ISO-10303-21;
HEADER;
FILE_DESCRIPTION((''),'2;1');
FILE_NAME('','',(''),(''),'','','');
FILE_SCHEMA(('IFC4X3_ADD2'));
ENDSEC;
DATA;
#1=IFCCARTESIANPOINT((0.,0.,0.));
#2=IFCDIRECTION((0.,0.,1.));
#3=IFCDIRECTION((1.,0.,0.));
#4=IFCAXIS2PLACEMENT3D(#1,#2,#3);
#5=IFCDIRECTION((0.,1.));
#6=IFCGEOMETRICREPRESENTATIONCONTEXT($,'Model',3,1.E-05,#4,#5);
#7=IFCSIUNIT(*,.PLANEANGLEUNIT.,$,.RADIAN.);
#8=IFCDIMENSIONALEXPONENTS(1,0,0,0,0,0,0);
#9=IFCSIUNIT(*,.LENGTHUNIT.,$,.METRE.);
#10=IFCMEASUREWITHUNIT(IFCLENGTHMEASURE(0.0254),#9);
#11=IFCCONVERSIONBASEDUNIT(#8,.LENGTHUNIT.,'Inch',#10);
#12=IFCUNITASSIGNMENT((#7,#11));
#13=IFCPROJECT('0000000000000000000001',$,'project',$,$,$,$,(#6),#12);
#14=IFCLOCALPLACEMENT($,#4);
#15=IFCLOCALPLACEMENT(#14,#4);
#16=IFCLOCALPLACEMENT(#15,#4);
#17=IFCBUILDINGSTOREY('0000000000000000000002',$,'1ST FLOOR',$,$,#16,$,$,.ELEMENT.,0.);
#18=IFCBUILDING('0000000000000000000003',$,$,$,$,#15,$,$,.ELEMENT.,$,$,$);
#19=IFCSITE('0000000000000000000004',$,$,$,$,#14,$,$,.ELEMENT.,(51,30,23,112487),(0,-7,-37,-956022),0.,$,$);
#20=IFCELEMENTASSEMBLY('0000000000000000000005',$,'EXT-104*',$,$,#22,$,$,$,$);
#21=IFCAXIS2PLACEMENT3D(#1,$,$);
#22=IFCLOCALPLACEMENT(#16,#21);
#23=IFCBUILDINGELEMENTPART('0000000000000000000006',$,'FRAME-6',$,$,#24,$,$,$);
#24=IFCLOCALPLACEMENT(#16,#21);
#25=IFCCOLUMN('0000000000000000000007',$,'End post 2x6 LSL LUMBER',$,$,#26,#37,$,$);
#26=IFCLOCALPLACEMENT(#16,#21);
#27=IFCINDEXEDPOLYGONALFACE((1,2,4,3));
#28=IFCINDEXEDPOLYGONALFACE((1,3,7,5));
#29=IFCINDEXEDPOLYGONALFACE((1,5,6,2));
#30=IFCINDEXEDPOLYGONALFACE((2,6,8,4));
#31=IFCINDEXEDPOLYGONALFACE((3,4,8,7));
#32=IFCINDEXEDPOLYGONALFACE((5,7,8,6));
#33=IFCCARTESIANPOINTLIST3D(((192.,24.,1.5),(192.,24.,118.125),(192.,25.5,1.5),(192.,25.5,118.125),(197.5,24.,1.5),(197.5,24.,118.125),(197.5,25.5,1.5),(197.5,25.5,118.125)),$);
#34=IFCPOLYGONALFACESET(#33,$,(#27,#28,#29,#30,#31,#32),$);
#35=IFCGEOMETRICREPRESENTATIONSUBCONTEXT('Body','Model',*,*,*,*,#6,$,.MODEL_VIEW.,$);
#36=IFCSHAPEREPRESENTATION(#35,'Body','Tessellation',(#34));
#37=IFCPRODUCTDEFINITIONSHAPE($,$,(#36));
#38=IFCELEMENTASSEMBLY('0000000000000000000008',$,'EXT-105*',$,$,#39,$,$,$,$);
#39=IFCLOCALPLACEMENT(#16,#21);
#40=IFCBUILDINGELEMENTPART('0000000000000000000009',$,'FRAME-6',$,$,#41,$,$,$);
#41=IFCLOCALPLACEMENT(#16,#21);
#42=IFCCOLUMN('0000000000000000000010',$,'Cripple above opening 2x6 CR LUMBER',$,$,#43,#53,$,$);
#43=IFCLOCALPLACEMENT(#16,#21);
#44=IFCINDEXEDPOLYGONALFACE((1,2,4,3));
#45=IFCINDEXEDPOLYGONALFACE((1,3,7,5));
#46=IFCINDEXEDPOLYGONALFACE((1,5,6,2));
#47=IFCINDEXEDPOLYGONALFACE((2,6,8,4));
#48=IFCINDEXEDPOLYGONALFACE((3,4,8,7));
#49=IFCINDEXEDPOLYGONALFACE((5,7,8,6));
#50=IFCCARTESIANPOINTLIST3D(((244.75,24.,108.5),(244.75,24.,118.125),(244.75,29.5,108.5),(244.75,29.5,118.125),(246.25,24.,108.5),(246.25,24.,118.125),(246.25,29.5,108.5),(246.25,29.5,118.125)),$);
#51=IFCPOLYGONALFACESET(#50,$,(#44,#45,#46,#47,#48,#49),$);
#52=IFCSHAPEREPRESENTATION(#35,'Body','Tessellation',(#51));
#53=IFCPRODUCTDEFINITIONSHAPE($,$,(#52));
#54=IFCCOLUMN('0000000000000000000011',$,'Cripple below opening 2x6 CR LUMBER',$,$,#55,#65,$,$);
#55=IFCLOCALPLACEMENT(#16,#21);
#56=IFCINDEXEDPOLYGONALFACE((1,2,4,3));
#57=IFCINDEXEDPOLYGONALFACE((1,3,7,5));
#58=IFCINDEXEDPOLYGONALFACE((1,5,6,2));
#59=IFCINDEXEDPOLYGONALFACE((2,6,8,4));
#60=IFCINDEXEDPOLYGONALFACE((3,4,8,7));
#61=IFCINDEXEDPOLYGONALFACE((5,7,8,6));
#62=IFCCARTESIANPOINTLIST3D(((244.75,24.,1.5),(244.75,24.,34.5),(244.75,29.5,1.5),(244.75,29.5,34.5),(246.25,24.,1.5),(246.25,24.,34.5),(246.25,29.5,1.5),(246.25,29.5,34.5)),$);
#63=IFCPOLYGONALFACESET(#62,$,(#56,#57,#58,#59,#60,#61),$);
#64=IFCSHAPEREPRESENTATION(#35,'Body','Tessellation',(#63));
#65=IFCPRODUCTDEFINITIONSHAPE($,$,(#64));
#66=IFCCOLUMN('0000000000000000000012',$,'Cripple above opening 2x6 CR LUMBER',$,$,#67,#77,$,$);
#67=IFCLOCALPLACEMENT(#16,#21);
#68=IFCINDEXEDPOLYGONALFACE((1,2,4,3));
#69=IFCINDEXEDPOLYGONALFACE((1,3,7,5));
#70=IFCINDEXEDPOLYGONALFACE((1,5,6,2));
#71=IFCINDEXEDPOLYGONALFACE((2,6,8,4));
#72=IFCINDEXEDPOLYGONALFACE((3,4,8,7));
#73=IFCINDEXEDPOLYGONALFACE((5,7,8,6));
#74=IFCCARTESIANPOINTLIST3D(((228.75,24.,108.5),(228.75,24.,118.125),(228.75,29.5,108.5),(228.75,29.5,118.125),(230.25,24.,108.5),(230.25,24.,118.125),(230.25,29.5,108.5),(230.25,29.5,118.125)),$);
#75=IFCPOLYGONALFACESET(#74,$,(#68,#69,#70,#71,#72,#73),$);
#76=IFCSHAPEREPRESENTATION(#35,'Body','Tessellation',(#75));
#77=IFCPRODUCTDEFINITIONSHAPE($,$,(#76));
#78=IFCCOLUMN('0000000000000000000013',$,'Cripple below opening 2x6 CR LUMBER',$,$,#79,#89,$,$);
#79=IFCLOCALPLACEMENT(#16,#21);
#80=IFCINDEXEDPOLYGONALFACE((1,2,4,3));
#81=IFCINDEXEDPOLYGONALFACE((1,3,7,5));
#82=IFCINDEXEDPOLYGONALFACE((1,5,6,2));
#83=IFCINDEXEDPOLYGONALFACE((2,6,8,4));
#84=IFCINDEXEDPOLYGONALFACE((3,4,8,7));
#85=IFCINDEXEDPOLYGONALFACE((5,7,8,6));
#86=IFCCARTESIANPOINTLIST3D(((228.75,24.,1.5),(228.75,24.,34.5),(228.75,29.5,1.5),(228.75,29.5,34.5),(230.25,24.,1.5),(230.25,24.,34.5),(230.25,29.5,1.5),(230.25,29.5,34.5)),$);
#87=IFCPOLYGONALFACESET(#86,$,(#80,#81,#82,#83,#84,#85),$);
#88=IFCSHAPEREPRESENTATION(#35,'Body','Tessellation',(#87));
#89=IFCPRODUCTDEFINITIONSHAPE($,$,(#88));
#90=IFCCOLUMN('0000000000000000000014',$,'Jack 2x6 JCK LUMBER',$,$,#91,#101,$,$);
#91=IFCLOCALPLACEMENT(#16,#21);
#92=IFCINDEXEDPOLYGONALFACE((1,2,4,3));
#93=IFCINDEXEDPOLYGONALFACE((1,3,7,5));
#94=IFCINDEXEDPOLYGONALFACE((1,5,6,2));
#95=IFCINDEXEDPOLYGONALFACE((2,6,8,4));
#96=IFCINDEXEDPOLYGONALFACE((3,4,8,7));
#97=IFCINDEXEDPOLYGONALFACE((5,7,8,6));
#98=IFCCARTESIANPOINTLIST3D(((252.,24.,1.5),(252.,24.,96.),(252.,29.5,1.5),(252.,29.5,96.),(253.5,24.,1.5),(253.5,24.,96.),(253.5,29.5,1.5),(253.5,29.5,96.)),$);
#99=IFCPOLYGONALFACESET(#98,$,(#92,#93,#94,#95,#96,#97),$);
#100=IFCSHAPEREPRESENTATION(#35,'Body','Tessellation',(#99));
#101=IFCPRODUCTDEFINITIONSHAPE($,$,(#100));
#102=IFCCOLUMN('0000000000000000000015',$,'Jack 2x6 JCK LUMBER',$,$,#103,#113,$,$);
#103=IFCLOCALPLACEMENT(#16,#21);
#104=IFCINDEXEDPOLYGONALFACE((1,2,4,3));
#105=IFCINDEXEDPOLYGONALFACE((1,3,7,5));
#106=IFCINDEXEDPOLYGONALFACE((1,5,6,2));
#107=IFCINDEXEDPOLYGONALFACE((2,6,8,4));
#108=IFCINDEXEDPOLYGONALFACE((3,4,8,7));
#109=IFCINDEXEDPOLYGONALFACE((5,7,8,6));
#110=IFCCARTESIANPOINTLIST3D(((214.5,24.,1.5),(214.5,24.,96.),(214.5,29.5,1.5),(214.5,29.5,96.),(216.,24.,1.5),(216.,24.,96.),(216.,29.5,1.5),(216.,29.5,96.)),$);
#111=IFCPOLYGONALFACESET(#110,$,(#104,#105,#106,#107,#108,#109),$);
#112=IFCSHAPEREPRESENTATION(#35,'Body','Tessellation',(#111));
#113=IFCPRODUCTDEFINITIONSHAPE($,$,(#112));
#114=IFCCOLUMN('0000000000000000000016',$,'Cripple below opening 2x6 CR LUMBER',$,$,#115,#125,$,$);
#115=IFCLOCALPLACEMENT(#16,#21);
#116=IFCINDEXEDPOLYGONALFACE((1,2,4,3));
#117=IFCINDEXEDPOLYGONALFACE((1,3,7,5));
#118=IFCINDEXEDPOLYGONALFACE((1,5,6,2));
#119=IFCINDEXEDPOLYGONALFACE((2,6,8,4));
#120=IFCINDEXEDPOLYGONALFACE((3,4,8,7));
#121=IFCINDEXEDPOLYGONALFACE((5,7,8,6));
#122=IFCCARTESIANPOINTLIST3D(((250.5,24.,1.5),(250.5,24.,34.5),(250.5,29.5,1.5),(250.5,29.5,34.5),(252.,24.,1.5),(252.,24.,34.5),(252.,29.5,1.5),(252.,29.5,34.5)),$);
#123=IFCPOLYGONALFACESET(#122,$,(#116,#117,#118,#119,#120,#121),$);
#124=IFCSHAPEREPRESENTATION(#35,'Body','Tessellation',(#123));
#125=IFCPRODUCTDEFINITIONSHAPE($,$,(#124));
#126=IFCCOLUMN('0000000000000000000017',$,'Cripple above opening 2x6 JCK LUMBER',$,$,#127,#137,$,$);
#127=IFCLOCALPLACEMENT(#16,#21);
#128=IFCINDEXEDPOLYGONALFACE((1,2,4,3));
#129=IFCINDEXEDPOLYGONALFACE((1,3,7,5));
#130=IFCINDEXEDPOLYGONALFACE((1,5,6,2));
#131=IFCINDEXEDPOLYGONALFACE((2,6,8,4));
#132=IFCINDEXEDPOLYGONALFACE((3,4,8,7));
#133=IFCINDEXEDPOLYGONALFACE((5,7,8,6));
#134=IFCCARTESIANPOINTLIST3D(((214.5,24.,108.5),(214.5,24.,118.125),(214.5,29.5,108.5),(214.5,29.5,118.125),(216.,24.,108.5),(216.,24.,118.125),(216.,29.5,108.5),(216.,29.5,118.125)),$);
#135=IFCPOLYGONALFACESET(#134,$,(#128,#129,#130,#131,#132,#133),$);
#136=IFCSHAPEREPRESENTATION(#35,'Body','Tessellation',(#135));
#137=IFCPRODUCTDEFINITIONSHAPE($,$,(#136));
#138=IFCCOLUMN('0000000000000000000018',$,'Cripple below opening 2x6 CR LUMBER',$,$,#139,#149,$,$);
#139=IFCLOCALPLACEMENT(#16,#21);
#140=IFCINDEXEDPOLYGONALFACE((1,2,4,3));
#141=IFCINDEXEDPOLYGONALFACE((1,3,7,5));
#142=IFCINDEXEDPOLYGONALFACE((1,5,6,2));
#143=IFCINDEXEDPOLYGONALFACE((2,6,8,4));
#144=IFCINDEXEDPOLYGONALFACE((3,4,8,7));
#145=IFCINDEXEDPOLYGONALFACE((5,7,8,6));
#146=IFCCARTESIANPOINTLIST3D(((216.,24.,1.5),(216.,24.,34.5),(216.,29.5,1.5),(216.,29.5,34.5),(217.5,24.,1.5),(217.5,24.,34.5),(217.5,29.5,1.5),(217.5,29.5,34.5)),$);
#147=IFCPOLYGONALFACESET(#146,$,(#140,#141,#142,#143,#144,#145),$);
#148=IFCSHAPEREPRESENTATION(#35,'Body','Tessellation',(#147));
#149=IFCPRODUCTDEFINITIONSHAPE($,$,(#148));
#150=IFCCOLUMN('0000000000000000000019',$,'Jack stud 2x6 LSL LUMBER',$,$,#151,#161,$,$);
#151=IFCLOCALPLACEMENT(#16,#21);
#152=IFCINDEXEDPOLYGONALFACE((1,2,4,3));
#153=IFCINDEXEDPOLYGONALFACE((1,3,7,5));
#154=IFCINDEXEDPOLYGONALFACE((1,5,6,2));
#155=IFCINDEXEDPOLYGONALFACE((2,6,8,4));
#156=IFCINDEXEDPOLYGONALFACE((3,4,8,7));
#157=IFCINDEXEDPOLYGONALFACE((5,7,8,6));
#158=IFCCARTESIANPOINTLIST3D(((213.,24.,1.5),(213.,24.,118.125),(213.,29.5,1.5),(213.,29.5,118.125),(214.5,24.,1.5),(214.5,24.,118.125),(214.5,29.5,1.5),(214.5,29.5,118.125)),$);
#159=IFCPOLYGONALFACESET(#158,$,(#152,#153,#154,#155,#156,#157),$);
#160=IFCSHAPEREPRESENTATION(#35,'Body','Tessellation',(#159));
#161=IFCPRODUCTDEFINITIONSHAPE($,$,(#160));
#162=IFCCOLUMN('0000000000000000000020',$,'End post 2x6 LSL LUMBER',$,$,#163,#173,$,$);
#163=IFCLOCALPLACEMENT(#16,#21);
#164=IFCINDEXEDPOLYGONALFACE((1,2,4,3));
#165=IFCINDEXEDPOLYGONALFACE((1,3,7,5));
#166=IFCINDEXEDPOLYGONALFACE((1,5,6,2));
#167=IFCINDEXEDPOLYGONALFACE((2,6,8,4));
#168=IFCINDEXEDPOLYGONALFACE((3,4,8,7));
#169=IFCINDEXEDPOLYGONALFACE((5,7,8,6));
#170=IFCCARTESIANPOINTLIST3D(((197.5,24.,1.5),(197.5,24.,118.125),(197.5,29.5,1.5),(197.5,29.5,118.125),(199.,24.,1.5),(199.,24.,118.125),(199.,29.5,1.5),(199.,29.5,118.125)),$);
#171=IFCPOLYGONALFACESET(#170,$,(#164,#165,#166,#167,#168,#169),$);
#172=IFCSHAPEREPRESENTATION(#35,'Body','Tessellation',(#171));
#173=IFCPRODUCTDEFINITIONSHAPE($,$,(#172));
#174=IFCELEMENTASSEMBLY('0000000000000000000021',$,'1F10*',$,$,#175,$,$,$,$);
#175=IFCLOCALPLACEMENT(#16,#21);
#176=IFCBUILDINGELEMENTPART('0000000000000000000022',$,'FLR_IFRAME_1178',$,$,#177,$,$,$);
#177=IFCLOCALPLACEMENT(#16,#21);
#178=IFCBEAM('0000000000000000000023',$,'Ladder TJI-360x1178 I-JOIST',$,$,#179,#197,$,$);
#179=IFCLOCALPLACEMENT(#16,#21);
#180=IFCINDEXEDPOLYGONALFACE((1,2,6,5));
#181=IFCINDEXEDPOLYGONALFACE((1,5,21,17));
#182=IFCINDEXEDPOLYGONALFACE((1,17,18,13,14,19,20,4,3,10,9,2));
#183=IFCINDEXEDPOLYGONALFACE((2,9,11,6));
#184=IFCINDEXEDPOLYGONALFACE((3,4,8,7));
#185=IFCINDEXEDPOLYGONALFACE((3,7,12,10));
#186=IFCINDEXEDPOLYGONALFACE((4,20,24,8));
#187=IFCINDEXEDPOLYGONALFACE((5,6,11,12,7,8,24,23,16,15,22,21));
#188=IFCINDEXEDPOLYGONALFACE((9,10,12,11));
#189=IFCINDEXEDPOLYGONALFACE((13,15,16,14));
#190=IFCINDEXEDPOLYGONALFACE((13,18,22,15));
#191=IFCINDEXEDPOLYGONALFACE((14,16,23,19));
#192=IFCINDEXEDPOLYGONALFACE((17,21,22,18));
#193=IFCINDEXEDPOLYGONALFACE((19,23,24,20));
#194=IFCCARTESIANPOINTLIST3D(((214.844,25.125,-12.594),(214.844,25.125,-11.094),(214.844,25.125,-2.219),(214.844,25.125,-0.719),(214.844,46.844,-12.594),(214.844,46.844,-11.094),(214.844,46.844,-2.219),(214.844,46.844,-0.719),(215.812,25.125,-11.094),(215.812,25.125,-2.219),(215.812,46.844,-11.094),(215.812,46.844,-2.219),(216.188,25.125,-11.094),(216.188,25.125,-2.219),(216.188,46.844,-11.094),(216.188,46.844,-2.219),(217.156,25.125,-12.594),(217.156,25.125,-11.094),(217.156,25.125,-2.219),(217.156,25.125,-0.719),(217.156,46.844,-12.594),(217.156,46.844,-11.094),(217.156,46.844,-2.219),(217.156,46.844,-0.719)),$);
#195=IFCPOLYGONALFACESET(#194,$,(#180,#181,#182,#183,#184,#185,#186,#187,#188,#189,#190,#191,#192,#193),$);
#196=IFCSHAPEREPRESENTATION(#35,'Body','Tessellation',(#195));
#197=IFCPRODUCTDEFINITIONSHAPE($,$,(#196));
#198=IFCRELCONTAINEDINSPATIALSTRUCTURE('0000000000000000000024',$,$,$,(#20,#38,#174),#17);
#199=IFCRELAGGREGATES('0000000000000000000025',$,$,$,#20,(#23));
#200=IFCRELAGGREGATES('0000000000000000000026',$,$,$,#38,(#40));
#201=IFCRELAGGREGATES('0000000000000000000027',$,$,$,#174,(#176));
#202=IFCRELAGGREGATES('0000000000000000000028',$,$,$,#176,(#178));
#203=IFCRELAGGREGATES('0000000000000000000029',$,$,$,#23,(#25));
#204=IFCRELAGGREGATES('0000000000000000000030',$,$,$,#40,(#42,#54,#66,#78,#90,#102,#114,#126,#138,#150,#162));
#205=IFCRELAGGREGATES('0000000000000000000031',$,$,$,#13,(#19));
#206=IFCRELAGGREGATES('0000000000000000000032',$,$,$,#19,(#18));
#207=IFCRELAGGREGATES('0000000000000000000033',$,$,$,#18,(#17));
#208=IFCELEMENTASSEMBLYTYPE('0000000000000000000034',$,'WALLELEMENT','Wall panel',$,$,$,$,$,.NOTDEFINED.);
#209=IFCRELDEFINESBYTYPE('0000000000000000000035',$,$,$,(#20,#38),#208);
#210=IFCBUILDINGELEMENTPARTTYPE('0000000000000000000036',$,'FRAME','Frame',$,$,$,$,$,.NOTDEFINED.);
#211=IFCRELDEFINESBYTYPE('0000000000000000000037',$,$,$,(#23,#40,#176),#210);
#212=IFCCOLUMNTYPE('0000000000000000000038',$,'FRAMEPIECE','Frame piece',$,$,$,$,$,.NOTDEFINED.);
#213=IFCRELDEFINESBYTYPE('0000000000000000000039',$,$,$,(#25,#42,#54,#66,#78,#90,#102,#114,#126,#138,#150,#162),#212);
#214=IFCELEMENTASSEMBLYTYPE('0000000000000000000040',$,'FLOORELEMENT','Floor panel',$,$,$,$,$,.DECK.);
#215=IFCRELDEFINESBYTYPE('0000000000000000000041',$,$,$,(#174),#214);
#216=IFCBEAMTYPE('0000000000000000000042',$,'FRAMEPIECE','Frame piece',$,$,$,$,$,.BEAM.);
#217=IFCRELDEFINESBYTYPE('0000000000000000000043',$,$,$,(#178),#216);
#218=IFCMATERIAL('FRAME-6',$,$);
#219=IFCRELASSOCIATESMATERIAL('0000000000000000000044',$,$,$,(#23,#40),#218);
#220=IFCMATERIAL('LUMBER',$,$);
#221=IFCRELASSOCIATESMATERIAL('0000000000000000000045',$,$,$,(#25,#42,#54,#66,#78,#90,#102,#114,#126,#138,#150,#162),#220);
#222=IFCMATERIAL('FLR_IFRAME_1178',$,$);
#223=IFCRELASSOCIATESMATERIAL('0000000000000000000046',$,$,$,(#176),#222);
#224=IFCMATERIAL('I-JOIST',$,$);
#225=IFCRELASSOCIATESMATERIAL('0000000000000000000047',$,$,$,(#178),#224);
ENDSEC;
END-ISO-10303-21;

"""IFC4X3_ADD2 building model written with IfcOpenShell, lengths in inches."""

from ifc_helpers import new_model, entity, si_unit, converted_unit, direction, frame, origin_with_axes, origin_2d_with_axis, place, context, subcontext, project, spatial, rectangle, i_section, extrude, material, type_object, element, aggregate, save


model = new_model("IFC4X3_ADD2")

# Units and contexts
model_context = context("Model", 3, precision=1e-05, world=origin_with_axes(), true_north=direction((0.0, 1.0)))
body_context = subcontext(model_context, "Body", "Model", "MODEL_VIEW")
ifc_project = project(units=[si_unit("PLANEANGLEUNIT", "RADIAN"), converted_unit("LENGTHUNIT", "Inch", entity("IfcLengthMeasure", 0.0254), si_unit("LENGTHUNIT", "METRE"), dimensions=[1, 0, 0, 0, 0, 0, 0])], contexts=[model_context])

# Site, building, storey
site_placement = place(None, origin_with_axes())
site = spatial("IfcSite", under=ifc_project, at=site_placement, CompositionType="ELEMENT", RefLatitude=(51, 30, 23, 112487), RefLongitude=(0, -7, -37, -956022), RefElevation=0.0)
building_placement = place(site_placement, origin_with_axes())
building = spatial("IfcBuilding", under=site, at=building_placement, CompositionType="ELEMENT")
storey_placement = place(building_placement, origin_with_axes())
storey = spatial("IfcBuildingStorey", under=building, at=storey_placement, Name="1ST FLOOR", CompositionType="ELEMENT", Elevation=0.0)

# Element assembly, building element part, column
element_assembly_type_1 = type_object("IfcElementAssemblyType", Name="WALLELEMENT", Description="Wall panel", PredefinedType="NOTDEFINED")
assembly_1_placement = place(storey_placement, origin_with_axes())
assembly_1 = element("IfcElementAssembly", 1, at=assembly_1_placement, inside=storey, type_object=element_assembly_type_1, Name="EXT-104*")
ifc_material_1 = material(Name="FRAME-6")
building_element_part_type = type_object("IfcBuildingElementPartType", Name="FRAME", Description="Frame", PredefinedType="NOTDEFINED")
building_element_part_1_placement = place(storey_placement, origin_with_axes())
building_element_part_1 = element("IfcBuildingElementPart", 2, at=building_element_part_1_placement, type_object=building_element_part_type, material=ifc_material_1, Name="FRAME-6")
aggregate(assembly_1, [building_element_part_1])
ifc_material_2 = material(Name="LUMBER")
column_type = type_object("IfcColumnType", Name="FRAMEPIECE", Description="Frame piece", PredefinedType="NOTDEFINED")
column_1_placement = place(storey_placement, frame((194.75, 24.75, 1.5), z_axis=(0.0, 0.0, 1.0), x_axis=(0.0, 1.0, 0.0)))
column_1 = element("IfcColumn", 3, at=column_1_placement, type_object=column_type, material=ifc_material_2, Name="End post 2x6 LSL LUMBER", context=body_context, shape_type="SweptSolid", body=[
    extrude(rectangle(XDim=1.5, YDim=5.5, at=origin_2d_with_axis()), origin_with_axes(), (0.0, 0.0, 1.0), 116.625),
])

# Element assembly, building element part, columns
assembly_2_placement = place(storey_placement, origin_with_axes())
assembly_2 = element("IfcElementAssembly", 4, at=assembly_2_placement, inside=storey, type_object=element_assembly_type_1, Name="EXT-105*")
building_element_part_2_placement = place(storey_placement, origin_with_axes())
building_element_part_2 = element("IfcBuildingElementPart", 5, at=building_element_part_2_placement, type_object=building_element_part_type, material=ifc_material_1, Name="FRAME-6")
aggregate(assembly_2, [building_element_part_2])
column_2_placement = place(storey_placement, frame((245.5, 26.75, 118.125), z_axis=(0.0, 0.0, -1.0), x_axis=(1.0, 0.0, 0.0)))
column_2 = element("IfcColumn", 6, at=column_2_placement, type_object=column_type, material=ifc_material_2, Name="Cripple above opening 2x6 CR LUMBER", context=body_context, shape_type="SweptSolid", body=[
    extrude(rectangle(XDim=1.5, YDim=5.5, at=origin_2d_with_axis()), origin_with_axes(), (0.0, 0.0, 1.0), 9.625),
])
column_3_placement = place(storey_placement, frame((245.5, 26.75, 34.5), z_axis=(0.0, 0.0, -1.0), x_axis=(1.0, 0.0, 0.0)))
column_3 = element("IfcColumn", 7, at=column_3_placement, type_object=column_type, material=ifc_material_2, Name="Cripple below opening 2x6 CR LUMBER", context=body_context, shape_type="SweptSolid", body=[
    extrude(rectangle(XDim=1.5, YDim=5.5, at=origin_2d_with_axis()), origin_with_axes(), (0.0, 0.0, 1.0), 33.0),
])
column_4_placement = place(storey_placement, frame((229.5, 26.75, 118.125), z_axis=(0.0, 0.0, -1.0), x_axis=(1.0, 0.0, 0.0)))
column_4 = element("IfcColumn", 8, at=column_4_placement, type_object=column_type, material=ifc_material_2, Name="Cripple above opening 2x6 CR LUMBER", context=body_context, shape_type="SweptSolid", body=[
    extrude(rectangle(XDim=1.5, YDim=5.5, at=origin_2d_with_axis()), origin_with_axes(), (0.0, 0.0, 1.0), 9.625),
])
column_5_placement = place(storey_placement, frame((229.5, 26.75, 34.5), z_axis=(0.0, 0.0, -1.0), x_axis=(1.0, 0.0, 0.0)))
column_5 = element("IfcColumn", 9, at=column_5_placement, type_object=column_type, material=ifc_material_2, Name="Cripple below opening 2x6 CR LUMBER", context=body_context, shape_type="SweptSolid", body=[
    extrude(rectangle(XDim=1.5, YDim=5.5, at=origin_2d_with_axis()), origin_with_axes(), (0.0, 0.0, 1.0), 33.0),
])
column_6_placement = place(storey_placement, frame((252.75, 26.75, 1.5), z_axis=(0.0, 0.0, 1.0), x_axis=(-1.0, 0.0, 0.0)))
column_6 = element("IfcColumn", 10, at=column_6_placement, type_object=column_type, material=ifc_material_2, Name="Jack 2x6 JCK LUMBER", context=body_context, shape_type="SweptSolid", body=[
    extrude(rectangle(XDim=1.5, YDim=5.5, at=origin_2d_with_axis()), origin_with_axes(), (0.0, 0.0, 1.0), 94.5),
])
column_7_placement = place(storey_placement, frame((215.25, 26.75, 96.0), z_axis=(0.0, 0.0, -1.0), x_axis=(1.0, 0.0, 0.0)))
column_7 = element("IfcColumn", 11, at=column_7_placement, type_object=column_type, material=ifc_material_2, Name="Jack 2x6 JCK LUMBER", context=body_context, shape_type="SweptSolid", body=[
    extrude(rectangle(XDim=1.5, YDim=5.5, at=origin_2d_with_axis()), origin_with_axes(), (0.0, 0.0, 1.0), 94.5),
])
column_8_placement = place(storey_placement, frame((251.25, 26.75, 1.5), z_axis=(0.0, 0.0, 1.0), x_axis=(-1.0, 0.0, 0.0)))
column_8 = element("IfcColumn", 12, at=column_8_placement, type_object=column_type, material=ifc_material_2, Name="Cripple below opening 2x6 CR LUMBER", context=body_context, shape_type="SweptSolid", body=[
    extrude(rectangle(XDim=1.5, YDim=5.5, at=origin_2d_with_axis()), origin_with_axes(), (0.0, 0.0, 1.0), 33.0),
])
column_9_placement = place(storey_placement, frame((215.25, 26.75, 118.125), z_axis=(0.0, 0.0, -1.0), x_axis=(1.0, 0.0, 0.0)))
column_9 = element("IfcColumn", 13, at=column_9_placement, type_object=column_type, material=ifc_material_2, Name="Cripple above opening 2x6 JCK LUMBER", context=body_context, shape_type="SweptSolid", body=[
    extrude(rectangle(XDim=1.5, YDim=5.5, at=origin_2d_with_axis()), origin_with_axes(), (0.0, 0.0, 1.0), 9.625),
])
column_10_placement = place(storey_placement, frame((216.75, 26.75, 34.5), z_axis=(0.0, 0.0, -1.0), x_axis=(1.0, 0.0, 0.0)))
column_10 = element("IfcColumn", 14, at=column_10_placement, type_object=column_type, material=ifc_material_2, Name="Cripple below opening 2x6 CR LUMBER", context=body_context, shape_type="SweptSolid", body=[
    extrude(rectangle(XDim=1.5, YDim=5.5, at=origin_2d_with_axis()), origin_with_axes(), (0.0, 0.0, 1.0), 33.0),
])
column_11_placement = place(storey_placement, frame((213.75, 26.75, 118.125), z_axis=(0.0, 0.0, -1.0), x_axis=(1.0, 0.0, 0.0)))
column_11 = element("IfcColumn", 15, at=column_11_placement, type_object=column_type, material=ifc_material_2, Name="Jack stud 2x6 LSL LUMBER", context=body_context, shape_type="SweptSolid", body=[
    extrude(rectangle(XDim=1.5, YDim=5.5, at=origin_2d_with_axis()), origin_with_axes(), (0.0, 0.0, 1.0), 116.625),
])
column_12_placement = place(storey_placement, frame((198.25, 26.75, 118.125), z_axis=(0.0, 0.0, -1.0), x_axis=(1.0, 0.0, 0.0)))
column_12 = element("IfcColumn", 16, at=column_12_placement, type_object=column_type, material=ifc_material_2, Name="End post 2x6 LSL LUMBER", context=body_context, shape_type="SweptSolid", body=[
    extrude(rectangle(XDim=1.5, YDim=5.5, at=origin_2d_with_axis()), origin_with_axes(), (0.0, 0.0, 1.0), 116.625),
])

# Element assembly, building element part, beam
element_assembly_type_2 = type_object("IfcElementAssemblyType", Name="FLOORELEMENT", Description="Floor panel", PredefinedType="DECK")
assembly_3_placement = place(storey_placement, origin_with_axes())
assembly_3 = element("IfcElementAssembly", 17, at=assembly_3_placement, inside=storey, type_object=element_assembly_type_2, Name="1F10*")
ifc_material_3 = material(Name="FLR_IFRAME_1178")
building_element_part_3_placement = place(storey_placement, origin_with_axes())
building_element_part_3 = element("IfcBuildingElementPart", 18, at=building_element_part_3_placement, type_object=building_element_part_type, material=ifc_material_3, Name="FLR_IFRAME_1178")
aggregate(assembly_3, [building_element_part_3])
ifc_material_4 = material(Name="I-JOIST")
beam_type = type_object("IfcBeamType", Name="FRAMEPIECE", Description="Frame piece", PredefinedType="BEAM")
beam_1_placement = place(storey_placement, frame((216.0, 25.125, -6.656), z_axis=(0.0, 1.0, 0.0), x_axis=(-1.0, 0.0, 0.0)))
beam_1 = element("IfcBeam", 19, at=beam_1_placement, type_object=beam_type, material=ifc_material_4, Name="Ladder TJI-360x1178 I-JOIST", context=body_context, shape_type="SweptSolid", body=[
    extrude(i_section(OverallWidth=2.313, OverallDepth=11.875, WebThickness=0.375, FlangeThickness=1.5, at=origin_2d_with_axis()), origin_with_axes(), (0.0, 0.0, 1.0), 21.719),
])
aggregate(building_element_part_3, [beam_1])

aggregate(building_element_part_1, [column_1])
aggregate(building_element_part_2, [column_2, column_3, column_4, column_5, column_6, column_7, column_8, column_9, column_10, column_11, column_12])

save(model, "model.ifc")
